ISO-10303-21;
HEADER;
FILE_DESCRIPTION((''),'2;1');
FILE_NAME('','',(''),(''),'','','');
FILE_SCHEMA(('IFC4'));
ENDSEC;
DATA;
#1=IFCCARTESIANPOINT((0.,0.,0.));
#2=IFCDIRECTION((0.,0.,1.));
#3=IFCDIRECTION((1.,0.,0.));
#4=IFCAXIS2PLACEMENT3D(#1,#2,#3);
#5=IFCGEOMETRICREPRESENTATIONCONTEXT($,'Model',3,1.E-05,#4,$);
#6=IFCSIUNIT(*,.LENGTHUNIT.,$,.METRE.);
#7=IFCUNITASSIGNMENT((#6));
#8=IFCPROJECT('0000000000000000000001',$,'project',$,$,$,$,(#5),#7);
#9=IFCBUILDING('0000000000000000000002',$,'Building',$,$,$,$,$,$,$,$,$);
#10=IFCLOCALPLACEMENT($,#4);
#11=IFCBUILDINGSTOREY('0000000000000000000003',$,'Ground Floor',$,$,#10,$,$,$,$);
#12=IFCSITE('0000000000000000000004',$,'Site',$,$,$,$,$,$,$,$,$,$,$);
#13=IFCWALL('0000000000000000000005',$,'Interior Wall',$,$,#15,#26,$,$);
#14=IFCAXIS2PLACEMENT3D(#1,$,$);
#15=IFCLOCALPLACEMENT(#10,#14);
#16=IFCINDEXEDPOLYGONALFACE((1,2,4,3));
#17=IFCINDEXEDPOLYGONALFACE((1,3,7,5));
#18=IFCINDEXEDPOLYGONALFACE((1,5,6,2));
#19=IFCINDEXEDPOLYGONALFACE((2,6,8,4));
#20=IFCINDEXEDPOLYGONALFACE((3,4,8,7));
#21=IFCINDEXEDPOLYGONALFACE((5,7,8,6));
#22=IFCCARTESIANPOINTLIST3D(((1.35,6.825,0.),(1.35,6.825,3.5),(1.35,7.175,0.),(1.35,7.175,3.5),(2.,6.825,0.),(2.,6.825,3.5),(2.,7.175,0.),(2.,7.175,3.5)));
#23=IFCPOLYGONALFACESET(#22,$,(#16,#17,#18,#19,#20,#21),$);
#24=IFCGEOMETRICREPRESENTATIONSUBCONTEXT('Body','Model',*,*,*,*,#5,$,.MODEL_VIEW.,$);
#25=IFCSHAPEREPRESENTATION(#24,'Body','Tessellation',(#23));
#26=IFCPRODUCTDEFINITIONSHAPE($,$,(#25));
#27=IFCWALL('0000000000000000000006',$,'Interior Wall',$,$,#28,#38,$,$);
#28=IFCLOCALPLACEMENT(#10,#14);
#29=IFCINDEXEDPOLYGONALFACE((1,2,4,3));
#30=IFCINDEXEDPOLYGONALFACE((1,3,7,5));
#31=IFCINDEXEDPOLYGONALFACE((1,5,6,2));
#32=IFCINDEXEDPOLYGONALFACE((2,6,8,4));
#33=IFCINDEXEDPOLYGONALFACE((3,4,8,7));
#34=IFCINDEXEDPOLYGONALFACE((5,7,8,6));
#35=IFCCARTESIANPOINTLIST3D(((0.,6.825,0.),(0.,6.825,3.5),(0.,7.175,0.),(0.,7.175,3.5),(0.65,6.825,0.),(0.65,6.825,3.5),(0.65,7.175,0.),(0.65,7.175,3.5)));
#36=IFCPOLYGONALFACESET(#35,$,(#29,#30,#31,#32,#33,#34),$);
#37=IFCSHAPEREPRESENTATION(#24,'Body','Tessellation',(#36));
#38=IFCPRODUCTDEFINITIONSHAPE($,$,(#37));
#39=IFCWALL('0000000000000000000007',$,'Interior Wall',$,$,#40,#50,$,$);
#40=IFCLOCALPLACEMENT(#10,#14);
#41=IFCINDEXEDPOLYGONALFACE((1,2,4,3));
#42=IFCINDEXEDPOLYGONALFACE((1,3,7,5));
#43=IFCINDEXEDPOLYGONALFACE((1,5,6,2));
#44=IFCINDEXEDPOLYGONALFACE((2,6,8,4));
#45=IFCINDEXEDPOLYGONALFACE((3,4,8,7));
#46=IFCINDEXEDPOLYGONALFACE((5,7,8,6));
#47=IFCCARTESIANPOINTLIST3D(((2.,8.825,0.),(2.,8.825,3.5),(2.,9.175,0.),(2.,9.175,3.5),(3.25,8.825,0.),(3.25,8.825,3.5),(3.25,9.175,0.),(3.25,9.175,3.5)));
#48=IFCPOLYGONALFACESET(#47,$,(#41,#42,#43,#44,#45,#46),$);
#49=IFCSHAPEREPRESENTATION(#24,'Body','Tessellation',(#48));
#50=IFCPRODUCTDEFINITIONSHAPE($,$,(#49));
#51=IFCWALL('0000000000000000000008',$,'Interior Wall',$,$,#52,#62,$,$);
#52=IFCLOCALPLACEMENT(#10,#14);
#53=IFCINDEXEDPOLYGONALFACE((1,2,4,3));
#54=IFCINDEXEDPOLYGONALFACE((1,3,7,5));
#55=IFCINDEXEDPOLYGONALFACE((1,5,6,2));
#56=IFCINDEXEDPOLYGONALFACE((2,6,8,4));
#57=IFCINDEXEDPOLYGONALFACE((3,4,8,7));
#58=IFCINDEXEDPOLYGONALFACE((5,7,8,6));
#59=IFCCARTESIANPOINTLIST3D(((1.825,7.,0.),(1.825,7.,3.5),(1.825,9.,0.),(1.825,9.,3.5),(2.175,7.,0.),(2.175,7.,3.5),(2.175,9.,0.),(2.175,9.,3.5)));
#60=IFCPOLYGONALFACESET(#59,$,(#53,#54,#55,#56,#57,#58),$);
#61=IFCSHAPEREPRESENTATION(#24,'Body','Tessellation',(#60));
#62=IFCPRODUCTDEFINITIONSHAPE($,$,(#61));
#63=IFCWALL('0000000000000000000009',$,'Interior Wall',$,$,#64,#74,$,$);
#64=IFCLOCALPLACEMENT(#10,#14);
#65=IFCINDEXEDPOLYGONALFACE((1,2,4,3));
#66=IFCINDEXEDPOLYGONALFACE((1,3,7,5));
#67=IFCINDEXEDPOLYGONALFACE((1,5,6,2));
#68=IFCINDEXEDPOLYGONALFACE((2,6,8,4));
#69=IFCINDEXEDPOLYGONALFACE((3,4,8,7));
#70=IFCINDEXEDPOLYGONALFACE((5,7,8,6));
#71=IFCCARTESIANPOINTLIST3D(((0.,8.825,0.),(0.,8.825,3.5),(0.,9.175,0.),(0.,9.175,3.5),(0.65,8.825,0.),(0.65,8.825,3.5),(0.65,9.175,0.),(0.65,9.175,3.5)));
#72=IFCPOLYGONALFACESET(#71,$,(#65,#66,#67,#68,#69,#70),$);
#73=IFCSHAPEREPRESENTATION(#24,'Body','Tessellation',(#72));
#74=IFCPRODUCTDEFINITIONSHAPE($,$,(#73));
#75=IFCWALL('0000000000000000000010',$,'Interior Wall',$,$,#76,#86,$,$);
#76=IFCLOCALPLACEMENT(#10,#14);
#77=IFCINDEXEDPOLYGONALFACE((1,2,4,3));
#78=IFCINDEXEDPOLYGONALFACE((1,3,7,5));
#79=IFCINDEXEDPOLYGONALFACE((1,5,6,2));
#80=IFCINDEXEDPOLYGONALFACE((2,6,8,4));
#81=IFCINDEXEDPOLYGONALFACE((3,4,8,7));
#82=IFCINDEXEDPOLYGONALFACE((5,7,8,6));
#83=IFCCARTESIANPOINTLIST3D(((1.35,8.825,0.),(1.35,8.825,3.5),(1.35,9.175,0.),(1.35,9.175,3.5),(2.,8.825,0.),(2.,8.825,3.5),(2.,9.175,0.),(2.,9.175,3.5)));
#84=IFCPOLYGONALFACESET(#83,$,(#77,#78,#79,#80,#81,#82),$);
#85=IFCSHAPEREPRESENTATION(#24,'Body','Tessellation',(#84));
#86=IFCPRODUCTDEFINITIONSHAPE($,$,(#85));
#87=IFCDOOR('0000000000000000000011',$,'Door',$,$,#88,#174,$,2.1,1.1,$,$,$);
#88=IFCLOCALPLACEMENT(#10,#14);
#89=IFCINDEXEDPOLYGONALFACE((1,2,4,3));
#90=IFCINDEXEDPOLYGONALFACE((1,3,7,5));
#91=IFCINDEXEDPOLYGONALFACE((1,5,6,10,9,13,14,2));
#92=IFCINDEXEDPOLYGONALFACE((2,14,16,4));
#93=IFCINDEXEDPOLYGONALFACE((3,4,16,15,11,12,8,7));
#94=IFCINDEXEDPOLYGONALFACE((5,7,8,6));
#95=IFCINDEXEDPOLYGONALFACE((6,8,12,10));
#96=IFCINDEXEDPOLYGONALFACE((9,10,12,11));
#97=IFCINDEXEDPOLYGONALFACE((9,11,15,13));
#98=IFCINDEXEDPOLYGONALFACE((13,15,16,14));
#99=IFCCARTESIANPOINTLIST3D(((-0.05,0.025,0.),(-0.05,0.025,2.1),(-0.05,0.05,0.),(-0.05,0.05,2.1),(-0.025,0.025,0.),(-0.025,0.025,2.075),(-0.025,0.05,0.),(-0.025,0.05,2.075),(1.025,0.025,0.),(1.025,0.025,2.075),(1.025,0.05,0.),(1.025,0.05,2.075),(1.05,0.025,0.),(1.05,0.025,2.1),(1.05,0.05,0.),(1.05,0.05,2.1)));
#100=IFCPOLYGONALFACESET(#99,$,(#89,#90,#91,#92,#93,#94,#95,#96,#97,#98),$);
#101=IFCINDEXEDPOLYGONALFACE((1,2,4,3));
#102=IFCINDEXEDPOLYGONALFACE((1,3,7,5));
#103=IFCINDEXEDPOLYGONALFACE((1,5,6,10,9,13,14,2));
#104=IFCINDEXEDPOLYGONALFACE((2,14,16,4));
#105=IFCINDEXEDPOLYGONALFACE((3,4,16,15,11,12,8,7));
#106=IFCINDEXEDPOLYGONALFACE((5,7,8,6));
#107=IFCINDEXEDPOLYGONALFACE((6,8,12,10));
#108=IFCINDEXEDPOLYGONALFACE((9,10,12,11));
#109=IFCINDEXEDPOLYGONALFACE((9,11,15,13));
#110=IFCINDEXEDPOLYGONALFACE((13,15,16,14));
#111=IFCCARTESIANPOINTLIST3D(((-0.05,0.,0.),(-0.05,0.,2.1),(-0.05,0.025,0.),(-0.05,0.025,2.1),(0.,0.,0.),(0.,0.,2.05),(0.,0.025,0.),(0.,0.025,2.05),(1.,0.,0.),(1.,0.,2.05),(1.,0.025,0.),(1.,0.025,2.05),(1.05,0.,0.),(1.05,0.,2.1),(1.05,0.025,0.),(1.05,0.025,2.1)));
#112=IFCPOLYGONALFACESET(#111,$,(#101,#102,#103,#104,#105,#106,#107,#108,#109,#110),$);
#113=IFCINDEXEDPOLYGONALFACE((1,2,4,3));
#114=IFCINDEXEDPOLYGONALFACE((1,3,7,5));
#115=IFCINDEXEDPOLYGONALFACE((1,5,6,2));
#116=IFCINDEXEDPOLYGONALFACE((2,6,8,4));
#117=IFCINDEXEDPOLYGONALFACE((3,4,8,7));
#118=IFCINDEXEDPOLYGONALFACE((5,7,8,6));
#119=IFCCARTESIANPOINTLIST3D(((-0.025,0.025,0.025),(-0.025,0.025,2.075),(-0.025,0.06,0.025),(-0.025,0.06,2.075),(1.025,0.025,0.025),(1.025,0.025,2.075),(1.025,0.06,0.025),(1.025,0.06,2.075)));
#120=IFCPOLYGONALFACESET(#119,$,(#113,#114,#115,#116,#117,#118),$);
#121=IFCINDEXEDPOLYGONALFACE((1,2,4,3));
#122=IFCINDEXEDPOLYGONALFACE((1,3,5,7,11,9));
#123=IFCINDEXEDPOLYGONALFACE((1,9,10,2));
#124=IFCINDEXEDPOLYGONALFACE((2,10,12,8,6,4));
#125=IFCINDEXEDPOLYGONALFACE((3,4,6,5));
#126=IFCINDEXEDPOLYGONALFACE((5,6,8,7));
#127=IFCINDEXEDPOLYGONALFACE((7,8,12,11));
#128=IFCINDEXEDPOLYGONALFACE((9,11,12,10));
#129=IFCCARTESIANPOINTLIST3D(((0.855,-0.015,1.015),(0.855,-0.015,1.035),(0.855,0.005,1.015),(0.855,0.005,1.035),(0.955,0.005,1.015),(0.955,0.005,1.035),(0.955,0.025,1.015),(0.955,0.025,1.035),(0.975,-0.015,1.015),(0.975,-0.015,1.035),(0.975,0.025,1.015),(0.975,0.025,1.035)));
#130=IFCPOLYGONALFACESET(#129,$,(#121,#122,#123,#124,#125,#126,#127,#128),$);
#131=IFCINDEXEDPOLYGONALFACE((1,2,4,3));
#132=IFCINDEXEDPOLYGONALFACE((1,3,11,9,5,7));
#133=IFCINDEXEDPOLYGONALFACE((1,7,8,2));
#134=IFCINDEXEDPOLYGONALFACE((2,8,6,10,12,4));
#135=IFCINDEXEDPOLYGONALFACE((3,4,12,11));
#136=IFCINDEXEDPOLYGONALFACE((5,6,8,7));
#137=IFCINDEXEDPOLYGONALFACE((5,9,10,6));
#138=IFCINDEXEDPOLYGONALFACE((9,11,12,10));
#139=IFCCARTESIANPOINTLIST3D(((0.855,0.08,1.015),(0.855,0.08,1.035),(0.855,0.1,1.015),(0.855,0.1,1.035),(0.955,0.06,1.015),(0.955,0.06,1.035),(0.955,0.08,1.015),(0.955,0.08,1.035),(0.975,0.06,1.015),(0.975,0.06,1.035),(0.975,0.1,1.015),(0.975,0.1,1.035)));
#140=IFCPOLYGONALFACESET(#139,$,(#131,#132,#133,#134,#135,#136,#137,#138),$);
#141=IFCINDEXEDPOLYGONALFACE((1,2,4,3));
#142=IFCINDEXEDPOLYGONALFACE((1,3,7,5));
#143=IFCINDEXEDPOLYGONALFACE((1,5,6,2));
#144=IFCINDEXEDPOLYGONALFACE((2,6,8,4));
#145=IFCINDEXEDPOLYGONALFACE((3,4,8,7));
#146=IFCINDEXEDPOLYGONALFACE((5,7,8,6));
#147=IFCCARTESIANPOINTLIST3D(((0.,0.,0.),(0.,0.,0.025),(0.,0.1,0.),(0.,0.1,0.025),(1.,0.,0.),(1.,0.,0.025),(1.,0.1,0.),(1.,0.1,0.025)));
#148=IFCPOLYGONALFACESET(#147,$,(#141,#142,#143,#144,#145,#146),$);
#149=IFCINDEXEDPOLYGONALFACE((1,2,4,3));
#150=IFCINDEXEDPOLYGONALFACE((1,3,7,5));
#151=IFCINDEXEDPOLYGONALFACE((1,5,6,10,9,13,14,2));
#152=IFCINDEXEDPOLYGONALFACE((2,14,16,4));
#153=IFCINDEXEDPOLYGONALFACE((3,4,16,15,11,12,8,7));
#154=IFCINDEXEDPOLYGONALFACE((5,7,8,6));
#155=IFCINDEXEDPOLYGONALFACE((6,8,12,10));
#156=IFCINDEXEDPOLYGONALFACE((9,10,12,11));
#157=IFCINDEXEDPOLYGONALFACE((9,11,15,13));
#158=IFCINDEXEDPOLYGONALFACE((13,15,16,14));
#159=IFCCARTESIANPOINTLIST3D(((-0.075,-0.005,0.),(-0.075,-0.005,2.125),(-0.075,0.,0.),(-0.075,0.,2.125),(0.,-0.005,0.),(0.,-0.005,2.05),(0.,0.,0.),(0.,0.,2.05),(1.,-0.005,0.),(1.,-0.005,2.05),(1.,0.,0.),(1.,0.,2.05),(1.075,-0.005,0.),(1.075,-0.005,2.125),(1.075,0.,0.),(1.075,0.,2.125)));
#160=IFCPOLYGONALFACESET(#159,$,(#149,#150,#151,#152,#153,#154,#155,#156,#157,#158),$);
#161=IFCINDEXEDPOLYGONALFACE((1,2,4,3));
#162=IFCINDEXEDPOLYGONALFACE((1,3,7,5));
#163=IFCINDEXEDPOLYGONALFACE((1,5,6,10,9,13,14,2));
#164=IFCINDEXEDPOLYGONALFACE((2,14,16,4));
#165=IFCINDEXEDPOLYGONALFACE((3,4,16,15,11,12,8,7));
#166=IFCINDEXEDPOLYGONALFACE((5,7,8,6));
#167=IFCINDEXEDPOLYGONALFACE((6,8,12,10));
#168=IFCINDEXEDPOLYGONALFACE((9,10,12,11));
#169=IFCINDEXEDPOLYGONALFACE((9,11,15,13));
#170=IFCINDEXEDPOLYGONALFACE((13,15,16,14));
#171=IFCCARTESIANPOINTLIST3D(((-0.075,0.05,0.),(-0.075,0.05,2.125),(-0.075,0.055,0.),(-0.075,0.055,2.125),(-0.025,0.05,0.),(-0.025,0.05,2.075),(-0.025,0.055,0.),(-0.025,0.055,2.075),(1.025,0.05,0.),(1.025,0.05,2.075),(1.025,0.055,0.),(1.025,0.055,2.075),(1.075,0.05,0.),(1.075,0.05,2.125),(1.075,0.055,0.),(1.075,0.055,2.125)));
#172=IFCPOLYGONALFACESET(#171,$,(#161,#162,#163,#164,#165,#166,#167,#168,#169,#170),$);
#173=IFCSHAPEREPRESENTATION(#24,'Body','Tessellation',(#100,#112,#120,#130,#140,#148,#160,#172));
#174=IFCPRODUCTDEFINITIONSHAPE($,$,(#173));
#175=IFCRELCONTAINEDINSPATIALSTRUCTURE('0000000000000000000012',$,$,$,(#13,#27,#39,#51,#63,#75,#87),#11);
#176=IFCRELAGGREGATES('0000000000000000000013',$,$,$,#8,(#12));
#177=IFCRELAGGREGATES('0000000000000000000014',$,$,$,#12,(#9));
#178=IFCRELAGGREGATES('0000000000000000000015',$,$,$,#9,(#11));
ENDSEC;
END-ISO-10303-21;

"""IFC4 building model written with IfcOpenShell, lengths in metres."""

from ifc_helpers import new_model, si_unit, frame, origin_with_axes, place, context, subcontext, project, spatial, line, indexed_curve, outline, extrude, element, save


model = new_model("IFC4")

# Units and contexts
model_context = context("Model", 3, precision=1e-05, world=origin_with_axes())
body_context = subcontext(model_context, "Body", "Model", "MODEL_VIEW")
ifc_project = project(units=[si_unit("LENGTHUNIT", "METRE")], contexts=[model_context])

# Site, building, storey
site = spatial("IfcSite", under=ifc_project, Name="Site")
building = spatial("IfcBuilding", under=site, Name="Building")
storey_placement = place(None, origin_with_axes())
storey = spatial("IfcBuildingStorey", under=building, at=storey_placement, Name="Ground Floor")

# Walls
for number, where, z_axis, x_axis, name in (
    (1, (2.0, 7.0, 0.0), (0.0, 0.0, 1.0), (-1.0, 0.0, 0.0), "Interior Wall"),
    (2, (0.65, 7.0, 0.0), (0.0, 0.0, 1.0), (-1.0, 0.0, 0.0), "Interior Wall"),
):
    element("IfcWall", number, at=place(storey_placement, frame(where, z_axis=z_axis, x_axis=x_axis)), inside=storey, Name=name, context=body_context, shape_type="SweptSolid", body=[
        extrude(outline(indexed_curve([(0.0, 0.0), (0.0, 0.35), (0.65, 0.35), (0.65, 0.0), (0.0, 0.0)], self_intersect=False)), frame((0.0, -0.175, 0.0), z_axis=(0.0, 0.0, 1.0), x_axis=(1.0, 0.0, 0.0)), (0.0, 0.0, 1.0), 3.5),
    ])
wall_1_placement = place(storey_placement, frame((3.25, 9.0, 0.0), z_axis=(0.0, 0.0, 1.0), x_axis=(-1.0, 0.0, 0.0)))
element("IfcWall", 3, at=wall_1_placement, inside=storey, Name="Interior Wall", context=body_context, shape_type="SweptSolid", body=[
    extrude(outline(indexed_curve([(0.0, 0.0), (0.0, 0.35), (1.25, 0.35), (1.25, 0.0), (0.0, 0.0)], self_intersect=False)), frame((0.0, -0.175, 0.0), z_axis=(0.0, 0.0, 1.0), x_axis=(1.0, 0.0, 0.0)), (0.0, 0.0, 1.0), 3.5),
])
wall_2_placement = place(storey_placement, frame((2.0, 9.0, 0.0), z_axis=(0.0, 0.0, 1.0), x_axis=(0.0, -1.0, 0.0)))
element("IfcWall", 4, at=wall_2_placement, inside=storey, Name="Interior Wall", context=body_context, shape_type="SweptSolid", body=[
    extrude(outline(indexed_curve([(0.0, 0.0), (0.0, 0.35), (2.0, 0.35), (2.0, 0.0), (0.0, 0.0)], self_intersect=False)), frame((0.0, -0.175, 0.0), z_axis=(0.0, 0.0, 1.0), x_axis=(1.0, 0.0, 0.0)), (0.0, 0.0, 1.0), 3.5),
])
wall_3_placement = place(storey_placement, frame((0.0, 9.0, 0.0), z_axis=(0.0, 0.0, 1.0), x_axis=(1.0, 0.0, 0.0)))
element("IfcWall", 5, at=wall_3_placement, inside=storey, Name="Interior Wall", context=body_context, shape_type="SweptSolid", body=[
    extrude(outline(indexed_curve([(0.0, 0.0), (0.0, 0.35), (0.65, 0.35), (0.65, 0.0), (0.0, 0.0)], self_intersect=False)), frame((0.0, -0.175, 0.0), z_axis=(0.0, 0.0, 1.0), x_axis=(1.0, 0.0, 0.0)), (0.0, 0.0, 1.0), 3.5),
])
wall_4_placement = place(storey_placement, frame((1.35, 9.0, 0.0), z_axis=(0.0, 0.0, 1.0), x_axis=(1.0, 0.0, 0.0)))
element("IfcWall", 6, at=wall_4_placement, inside=storey, Name="Interior Wall", context=body_context, shape_type="SweptSolid", body=[
    extrude(outline(indexed_curve([(0.0, 0.0), (0.0, 0.35), (0.65, 0.35), (0.65, 0.0), (0.0, 0.0)], self_intersect=False)), frame((0.0, -0.175, 0.0), z_axis=(0.0, 0.0, 1.0), x_axis=(1.0, 0.0, 0.0)), (0.0, 0.0, 1.0), 3.5),
])

# Door
door_1_placement = place(storey_placement, frame((-0.05, 0.0, 0.0), z_axis=(0.0, 0.0, 1.0), x_axis=(1.0, 0.0, 0.0)))
element("IfcDoor", 7, at=door_1_placement, inside=storey, Name="Door", OverallHeight=2.1, OverallWidth=1.1, context=body_context, shape_type="SweptSolid", body=[
    extrude(outline(indexed_curve([(0.0, 0.0), (0.0, 2.1), (1.1, 2.1), (1.1, 0.0), (1.075, 0.0), (1.075, 2.075), (0.025, 2.075), (0.025, 0.0)], segments=[line(1, 2, 3, 4, 5, 6, 7, 8, 1)])), frame((0.0, 0.025, 0.0), z_axis=(0.0, -1.0, 0.0), x_axis=(1.0, 0.0, 0.0)), (0.0, 0.0, -1.0), 0.025),
    extrude(outline(indexed_curve([(0.0, 0.0), (0.0, 2.1), (1.1, 2.1), (1.1, 0.0), (1.05, 0.0), (1.05, 2.05), (0.05, 2.05), (0.05, 0.0)], segments=[line(1, 2, 3, 4, 5, 6, 7, 8, 1)])), frame((0.0, 0.0, 0.0), z_axis=(0.0, -1.0, 0.0), x_axis=(1.0, 0.0, 0.0)), (0.0, 0.0, -1.0), 0.025),
    extrude(outline(indexed_curve([(0.0, 0.0), (1.05, 0.0), (1.05, 0.035), (0.0, 0.035)], segments=[line(1, 2, 3, 4, 1)])), frame((0.025, 0.025, 0.025), z_axis=(0.0, 0.0, 1.0), x_axis=(1.0, 0.0, 0.0)), (0.0, 0.0, 1.0), 2.05),
    extrude(outline(indexed_curve([(0.0, 0.0), (0.0, -0.04), (-0.12, -0.04), (-0.12, -0.02), (-0.02, -0.02), (-0.02, 0.0)], segments=[line(1, 2, 3, 4, 5, 6, 1)])), frame((1.025, 0.025, 1.015), z_axis=(0.0, 0.0, 1.0), x_axis=(1.0, 0.0, 0.0)), (0.0, 0.0, 1.0), 0.02),
    extrude(outline(indexed_curve([(0.0, 0.0), (0.0, 0.04), (-0.12, 0.04), (-0.12, 0.02), (-0.02, 0.02), (-0.02, 0.0)], segments=[line(1, 2, 3, 4, 5, 6, 1)])), frame((1.025, 0.06, 1.015), z_axis=(0.0, 0.0, 1.0), x_axis=(1.0, 0.0, 0.0)), (0.0, 0.0, 1.0), 0.02),
    extrude(outline(indexed_curve([(0.0, 0.0), (1.0, 0.0), (1.0, 0.1), (0.0, 0.1)], segments=[line(1, 2, 3, 4, 1)])), frame((0.05, 0.0, 0.0), z_axis=(0.0, 0.0, 1.0), x_axis=(1.0, 0.0, 0.0)), (0.0, 0.0, 1.0), 0.025),
    extrude(outline(indexed_curve([(0.0, 0.0), (0.0, 2.125), (1.15, 2.125), (1.15, 0.0), (1.075, 0.0), (1.075, 2.05), (0.075, 2.05), (0.075, 0.0)], segments=[line(1, 2, 3, 4, 5, 6, 7, 8, 1)])), frame((-0.025, -0.005, 0.0), z_axis=(0.0, -1.0, 0.0), x_axis=(1.0, 0.0, 0.0)), (0.0, 0.0, -1.0), 0.005),
    extrude(outline(indexed_curve([(0.0, 0.0), (0.0, 2.125), (1.15, 2.125), (1.15, 0.0), (1.1, 0.0), (1.1, 2.075), (0.05, 2.075), (0.05, 0.0)], segments=[line(1, 2, 3, 4, 5, 6, 7, 8, 1)])), frame((-0.025, 0.05, 0.0), z_axis=(0.0, -1.0, 0.0), x_axis=(1.0, 0.0, 0.0)), (0.0, 0.0, -1.0), 0.005),
])

save(model, "model.ifc")
